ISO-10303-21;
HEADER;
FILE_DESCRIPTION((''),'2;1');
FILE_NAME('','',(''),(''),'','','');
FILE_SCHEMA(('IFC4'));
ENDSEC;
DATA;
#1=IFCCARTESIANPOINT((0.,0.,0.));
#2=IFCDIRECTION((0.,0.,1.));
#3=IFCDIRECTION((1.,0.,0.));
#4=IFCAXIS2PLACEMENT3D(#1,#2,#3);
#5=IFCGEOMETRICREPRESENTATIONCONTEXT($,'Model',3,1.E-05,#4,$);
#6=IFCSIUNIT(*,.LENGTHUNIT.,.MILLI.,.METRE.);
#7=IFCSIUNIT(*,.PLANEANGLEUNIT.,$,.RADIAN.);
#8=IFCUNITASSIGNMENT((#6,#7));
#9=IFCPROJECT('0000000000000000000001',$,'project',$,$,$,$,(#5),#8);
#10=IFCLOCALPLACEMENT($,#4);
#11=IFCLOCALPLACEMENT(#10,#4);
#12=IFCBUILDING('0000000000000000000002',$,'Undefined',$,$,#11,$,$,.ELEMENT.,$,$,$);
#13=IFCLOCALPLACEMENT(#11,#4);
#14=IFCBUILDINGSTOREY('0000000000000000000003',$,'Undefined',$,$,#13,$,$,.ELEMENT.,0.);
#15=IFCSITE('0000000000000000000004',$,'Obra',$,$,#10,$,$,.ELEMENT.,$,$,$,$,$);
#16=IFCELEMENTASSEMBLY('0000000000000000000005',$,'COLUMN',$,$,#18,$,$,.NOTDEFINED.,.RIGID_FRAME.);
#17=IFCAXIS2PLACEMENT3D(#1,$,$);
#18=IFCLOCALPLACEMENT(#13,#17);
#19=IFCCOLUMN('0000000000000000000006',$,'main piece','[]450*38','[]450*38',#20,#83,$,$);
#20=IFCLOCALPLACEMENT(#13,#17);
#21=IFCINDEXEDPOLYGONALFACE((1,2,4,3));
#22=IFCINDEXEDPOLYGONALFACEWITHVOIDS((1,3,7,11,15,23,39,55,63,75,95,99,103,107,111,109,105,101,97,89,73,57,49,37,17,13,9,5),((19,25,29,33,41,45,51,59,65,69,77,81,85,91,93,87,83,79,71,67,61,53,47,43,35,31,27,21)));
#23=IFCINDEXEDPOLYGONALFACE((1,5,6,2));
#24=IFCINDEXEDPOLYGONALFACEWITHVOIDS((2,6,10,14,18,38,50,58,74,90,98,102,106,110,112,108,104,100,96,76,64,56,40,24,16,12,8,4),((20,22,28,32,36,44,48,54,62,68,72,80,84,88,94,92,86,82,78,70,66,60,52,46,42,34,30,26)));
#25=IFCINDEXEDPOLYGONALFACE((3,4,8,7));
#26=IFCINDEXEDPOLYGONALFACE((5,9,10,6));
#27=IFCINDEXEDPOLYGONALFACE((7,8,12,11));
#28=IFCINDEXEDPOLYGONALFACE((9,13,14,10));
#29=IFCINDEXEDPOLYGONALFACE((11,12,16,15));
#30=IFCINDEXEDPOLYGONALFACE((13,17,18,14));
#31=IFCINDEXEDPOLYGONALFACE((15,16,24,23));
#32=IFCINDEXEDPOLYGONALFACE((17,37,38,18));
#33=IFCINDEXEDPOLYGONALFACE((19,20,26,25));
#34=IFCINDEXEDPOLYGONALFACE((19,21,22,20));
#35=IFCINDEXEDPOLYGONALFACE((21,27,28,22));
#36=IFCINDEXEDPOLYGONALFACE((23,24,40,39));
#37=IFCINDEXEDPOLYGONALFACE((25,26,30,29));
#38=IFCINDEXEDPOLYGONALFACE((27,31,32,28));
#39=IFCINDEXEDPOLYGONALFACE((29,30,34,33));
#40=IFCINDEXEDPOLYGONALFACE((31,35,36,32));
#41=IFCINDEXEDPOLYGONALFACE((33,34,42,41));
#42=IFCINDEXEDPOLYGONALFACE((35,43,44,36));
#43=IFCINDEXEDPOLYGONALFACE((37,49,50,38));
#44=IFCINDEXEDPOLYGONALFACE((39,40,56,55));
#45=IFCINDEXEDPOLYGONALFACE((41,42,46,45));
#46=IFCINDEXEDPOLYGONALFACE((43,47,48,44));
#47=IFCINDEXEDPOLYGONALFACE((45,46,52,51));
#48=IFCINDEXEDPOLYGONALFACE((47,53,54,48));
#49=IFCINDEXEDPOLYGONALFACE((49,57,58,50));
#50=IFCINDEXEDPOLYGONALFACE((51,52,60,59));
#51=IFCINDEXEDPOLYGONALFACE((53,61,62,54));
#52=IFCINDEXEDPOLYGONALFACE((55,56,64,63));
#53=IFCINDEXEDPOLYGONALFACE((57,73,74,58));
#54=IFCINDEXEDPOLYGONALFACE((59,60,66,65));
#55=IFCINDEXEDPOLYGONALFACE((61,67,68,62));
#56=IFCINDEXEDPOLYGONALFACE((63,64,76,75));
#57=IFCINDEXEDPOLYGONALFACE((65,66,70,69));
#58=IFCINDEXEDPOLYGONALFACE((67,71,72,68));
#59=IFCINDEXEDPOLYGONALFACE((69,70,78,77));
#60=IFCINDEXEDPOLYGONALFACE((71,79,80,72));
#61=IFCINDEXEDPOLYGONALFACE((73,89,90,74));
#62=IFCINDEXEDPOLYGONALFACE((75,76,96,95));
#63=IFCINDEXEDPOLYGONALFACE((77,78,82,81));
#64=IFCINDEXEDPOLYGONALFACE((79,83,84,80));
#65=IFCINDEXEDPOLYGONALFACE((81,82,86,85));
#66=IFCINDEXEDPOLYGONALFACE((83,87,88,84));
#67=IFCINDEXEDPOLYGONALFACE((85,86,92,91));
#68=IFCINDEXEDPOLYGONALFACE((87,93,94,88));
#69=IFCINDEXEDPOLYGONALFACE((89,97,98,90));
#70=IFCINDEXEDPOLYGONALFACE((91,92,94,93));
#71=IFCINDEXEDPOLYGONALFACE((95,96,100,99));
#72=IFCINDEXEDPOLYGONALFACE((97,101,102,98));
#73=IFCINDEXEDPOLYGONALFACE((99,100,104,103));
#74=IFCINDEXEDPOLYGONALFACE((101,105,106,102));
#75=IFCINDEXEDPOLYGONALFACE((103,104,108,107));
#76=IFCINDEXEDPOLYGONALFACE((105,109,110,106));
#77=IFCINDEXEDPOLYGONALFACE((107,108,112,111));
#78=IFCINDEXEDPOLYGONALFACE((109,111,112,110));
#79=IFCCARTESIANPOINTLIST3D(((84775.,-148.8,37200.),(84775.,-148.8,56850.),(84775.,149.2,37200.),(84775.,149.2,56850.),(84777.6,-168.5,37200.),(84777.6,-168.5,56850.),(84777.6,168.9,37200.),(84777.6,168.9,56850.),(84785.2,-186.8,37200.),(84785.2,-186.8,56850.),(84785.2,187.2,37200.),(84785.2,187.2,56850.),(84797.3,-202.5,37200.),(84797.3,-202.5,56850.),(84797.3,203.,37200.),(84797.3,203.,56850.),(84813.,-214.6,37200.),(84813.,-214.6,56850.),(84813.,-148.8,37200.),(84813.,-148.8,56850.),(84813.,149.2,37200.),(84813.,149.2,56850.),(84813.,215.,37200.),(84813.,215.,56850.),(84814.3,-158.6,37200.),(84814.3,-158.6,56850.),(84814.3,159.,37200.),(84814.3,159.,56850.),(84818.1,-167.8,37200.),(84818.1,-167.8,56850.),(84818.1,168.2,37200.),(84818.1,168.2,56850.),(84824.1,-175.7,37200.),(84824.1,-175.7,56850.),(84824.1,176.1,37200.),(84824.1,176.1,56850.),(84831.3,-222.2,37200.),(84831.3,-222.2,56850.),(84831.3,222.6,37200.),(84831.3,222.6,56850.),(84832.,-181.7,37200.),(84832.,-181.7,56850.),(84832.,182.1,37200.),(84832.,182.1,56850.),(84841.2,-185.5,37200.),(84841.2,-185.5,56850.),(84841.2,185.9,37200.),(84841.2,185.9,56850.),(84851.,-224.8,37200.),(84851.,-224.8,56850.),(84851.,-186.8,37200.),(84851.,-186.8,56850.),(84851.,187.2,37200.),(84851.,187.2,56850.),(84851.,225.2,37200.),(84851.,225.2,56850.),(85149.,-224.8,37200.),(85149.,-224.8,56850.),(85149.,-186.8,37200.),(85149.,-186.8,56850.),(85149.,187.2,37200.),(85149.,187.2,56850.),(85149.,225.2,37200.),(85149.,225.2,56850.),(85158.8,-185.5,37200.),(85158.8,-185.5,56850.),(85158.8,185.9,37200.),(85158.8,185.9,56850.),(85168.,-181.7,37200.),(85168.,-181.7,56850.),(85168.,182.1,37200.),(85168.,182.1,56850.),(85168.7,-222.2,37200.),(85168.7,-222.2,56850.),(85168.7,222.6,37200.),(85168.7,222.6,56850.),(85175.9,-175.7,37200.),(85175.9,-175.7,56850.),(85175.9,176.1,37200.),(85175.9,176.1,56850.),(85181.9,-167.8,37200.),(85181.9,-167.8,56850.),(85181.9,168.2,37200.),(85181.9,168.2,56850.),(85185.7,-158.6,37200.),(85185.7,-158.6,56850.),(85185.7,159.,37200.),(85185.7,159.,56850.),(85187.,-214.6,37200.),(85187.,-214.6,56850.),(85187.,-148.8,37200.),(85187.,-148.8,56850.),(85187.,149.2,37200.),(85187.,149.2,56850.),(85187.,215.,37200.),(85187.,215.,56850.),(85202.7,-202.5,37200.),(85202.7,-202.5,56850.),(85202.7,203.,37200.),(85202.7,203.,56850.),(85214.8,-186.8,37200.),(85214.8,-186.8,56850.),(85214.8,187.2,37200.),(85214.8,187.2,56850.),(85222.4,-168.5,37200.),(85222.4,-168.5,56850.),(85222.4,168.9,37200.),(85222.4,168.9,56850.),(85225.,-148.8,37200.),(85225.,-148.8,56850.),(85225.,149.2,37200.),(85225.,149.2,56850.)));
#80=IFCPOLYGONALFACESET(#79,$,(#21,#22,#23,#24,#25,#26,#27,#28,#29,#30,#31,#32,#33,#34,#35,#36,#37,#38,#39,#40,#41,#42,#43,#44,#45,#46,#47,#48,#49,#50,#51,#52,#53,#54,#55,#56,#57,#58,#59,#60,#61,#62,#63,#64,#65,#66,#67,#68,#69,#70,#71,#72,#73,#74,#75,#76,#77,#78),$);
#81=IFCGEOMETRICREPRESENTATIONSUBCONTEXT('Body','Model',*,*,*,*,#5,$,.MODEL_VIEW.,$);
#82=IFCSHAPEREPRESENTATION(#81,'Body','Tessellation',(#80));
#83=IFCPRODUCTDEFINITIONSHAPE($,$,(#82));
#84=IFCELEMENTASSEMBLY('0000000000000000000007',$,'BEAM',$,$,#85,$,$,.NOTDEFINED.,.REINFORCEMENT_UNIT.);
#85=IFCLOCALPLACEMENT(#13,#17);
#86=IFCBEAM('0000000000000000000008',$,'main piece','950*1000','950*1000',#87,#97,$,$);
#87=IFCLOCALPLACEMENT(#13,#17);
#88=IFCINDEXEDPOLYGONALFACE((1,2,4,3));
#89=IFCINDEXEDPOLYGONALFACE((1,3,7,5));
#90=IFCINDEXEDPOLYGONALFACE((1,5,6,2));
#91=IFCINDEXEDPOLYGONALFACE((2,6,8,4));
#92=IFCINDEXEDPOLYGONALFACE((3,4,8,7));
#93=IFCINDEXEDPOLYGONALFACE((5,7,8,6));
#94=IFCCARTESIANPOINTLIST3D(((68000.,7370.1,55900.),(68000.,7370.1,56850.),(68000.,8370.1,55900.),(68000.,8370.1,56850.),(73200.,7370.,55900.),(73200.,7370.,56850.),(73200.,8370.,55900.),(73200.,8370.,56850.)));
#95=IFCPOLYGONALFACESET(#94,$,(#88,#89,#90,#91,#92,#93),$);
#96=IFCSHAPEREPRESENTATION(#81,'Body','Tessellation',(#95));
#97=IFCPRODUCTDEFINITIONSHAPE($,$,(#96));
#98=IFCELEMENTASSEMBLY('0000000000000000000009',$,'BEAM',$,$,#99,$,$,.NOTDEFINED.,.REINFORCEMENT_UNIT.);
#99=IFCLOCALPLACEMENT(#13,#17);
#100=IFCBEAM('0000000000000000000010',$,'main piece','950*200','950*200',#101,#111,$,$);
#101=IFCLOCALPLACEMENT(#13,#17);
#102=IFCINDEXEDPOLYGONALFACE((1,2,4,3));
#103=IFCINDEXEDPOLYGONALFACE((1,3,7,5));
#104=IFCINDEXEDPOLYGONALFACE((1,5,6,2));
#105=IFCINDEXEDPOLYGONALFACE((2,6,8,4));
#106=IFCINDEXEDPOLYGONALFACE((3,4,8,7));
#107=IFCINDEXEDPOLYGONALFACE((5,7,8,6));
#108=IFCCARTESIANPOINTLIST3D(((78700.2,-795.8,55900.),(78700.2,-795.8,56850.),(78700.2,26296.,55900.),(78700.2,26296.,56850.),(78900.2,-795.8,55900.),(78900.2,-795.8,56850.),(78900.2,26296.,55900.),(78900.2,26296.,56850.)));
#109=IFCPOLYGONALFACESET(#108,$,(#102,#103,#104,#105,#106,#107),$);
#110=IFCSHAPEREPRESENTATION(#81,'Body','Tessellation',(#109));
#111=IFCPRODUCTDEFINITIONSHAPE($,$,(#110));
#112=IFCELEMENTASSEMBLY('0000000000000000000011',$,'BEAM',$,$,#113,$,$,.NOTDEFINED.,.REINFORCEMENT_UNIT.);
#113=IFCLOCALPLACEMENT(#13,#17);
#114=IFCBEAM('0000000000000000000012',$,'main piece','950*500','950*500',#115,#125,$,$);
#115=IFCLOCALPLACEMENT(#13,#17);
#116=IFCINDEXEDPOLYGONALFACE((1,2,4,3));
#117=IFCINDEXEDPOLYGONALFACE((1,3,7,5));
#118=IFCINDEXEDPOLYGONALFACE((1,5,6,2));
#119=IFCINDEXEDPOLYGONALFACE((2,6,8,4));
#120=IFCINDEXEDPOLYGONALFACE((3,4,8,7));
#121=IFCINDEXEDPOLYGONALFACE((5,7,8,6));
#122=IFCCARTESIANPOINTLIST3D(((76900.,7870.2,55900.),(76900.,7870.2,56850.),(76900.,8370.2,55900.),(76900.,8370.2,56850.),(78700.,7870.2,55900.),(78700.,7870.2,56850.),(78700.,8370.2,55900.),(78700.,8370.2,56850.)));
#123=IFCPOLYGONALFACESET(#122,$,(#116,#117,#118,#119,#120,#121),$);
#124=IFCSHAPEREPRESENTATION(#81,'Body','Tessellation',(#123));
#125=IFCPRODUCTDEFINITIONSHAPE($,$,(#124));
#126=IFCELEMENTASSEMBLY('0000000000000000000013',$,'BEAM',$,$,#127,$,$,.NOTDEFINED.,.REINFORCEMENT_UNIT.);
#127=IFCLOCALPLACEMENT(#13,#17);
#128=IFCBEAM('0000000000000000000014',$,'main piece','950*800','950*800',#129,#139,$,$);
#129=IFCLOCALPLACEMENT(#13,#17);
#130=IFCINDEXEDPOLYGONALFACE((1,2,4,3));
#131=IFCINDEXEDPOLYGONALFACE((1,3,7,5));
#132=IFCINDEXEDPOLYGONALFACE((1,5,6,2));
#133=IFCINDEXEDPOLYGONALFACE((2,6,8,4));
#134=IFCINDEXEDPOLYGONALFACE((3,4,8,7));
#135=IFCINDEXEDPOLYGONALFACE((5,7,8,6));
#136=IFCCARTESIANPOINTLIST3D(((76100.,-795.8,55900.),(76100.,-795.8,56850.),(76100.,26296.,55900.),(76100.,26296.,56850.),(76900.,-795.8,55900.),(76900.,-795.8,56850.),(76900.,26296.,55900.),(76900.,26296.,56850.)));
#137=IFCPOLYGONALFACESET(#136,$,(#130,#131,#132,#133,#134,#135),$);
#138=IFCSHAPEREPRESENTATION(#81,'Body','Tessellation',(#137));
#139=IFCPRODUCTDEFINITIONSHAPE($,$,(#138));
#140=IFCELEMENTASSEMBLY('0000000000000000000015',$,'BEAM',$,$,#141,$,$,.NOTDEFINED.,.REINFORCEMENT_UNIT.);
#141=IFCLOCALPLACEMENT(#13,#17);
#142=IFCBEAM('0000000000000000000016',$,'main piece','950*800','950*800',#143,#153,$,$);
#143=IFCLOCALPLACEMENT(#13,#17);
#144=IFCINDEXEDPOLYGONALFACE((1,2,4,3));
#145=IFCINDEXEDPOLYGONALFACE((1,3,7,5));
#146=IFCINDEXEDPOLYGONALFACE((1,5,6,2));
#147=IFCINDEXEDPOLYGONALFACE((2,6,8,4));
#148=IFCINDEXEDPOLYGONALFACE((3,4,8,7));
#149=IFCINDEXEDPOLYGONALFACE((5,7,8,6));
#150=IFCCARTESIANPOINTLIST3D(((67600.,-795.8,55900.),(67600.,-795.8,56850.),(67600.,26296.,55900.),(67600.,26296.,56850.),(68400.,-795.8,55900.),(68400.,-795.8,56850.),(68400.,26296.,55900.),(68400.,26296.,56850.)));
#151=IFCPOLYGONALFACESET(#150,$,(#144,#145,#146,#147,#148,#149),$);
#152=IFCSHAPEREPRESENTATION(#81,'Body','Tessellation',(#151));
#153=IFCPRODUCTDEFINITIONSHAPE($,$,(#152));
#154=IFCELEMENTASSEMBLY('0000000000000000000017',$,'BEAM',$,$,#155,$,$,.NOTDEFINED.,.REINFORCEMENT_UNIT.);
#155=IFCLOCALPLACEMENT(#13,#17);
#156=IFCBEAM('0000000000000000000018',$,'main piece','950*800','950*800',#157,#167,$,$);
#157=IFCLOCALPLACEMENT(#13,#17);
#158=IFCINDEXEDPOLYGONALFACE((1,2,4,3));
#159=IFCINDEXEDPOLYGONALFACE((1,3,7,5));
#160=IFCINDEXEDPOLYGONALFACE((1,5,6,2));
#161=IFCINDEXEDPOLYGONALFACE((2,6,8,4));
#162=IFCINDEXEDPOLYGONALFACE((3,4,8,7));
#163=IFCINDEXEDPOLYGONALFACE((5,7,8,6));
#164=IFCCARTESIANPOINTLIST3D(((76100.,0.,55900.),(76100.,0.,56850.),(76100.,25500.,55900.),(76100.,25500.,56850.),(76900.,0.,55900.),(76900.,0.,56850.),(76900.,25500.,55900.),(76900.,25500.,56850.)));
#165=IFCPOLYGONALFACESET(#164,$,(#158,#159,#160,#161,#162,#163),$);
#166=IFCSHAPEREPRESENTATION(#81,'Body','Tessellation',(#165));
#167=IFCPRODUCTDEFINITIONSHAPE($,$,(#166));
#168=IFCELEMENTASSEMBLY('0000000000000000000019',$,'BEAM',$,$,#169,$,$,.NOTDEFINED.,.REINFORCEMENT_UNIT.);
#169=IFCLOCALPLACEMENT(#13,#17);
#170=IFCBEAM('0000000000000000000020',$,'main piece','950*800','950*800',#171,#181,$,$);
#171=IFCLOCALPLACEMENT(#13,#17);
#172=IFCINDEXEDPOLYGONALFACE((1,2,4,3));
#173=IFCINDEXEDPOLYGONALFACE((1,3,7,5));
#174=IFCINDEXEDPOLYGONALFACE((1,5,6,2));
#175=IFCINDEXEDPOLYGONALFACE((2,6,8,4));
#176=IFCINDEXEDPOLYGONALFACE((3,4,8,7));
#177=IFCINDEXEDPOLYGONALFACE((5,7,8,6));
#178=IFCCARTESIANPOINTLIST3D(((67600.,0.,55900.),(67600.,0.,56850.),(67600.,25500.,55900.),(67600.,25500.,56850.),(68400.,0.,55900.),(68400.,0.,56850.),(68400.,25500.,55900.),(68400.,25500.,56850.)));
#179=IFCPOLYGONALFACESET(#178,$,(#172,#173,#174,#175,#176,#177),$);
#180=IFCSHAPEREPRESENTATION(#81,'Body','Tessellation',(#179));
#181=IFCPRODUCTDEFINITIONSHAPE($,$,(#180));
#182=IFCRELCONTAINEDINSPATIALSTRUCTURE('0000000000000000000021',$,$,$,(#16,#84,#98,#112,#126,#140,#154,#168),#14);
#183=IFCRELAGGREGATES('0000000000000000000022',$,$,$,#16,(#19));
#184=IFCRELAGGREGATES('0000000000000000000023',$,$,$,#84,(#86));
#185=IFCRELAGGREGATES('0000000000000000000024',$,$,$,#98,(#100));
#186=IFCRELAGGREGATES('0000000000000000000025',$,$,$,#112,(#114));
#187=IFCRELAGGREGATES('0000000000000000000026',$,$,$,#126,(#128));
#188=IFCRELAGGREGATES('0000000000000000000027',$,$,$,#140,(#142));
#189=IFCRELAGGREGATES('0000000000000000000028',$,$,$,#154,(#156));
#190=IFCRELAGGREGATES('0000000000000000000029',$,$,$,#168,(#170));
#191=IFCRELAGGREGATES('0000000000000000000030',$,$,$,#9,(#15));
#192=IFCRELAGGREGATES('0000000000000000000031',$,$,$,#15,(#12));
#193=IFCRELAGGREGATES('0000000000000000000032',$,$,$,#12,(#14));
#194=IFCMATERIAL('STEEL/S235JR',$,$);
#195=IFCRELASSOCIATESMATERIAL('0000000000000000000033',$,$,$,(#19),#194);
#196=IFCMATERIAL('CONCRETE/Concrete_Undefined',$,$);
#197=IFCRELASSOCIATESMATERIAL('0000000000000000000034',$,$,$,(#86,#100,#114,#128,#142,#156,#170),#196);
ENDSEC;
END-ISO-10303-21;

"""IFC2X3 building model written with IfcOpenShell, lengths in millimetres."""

from ifc_helpers import new_model, si_unit, frame, origin_with_axes, origin_2d_with_axis, place, context, subcontext, project, spatial, rectangle, hollow_rectangle, extrude, material, element, aggregate, save


model = new_model("IFC2X3")

# Units and contexts
model_context = context("Model", 3, precision=1e-05, world=origin_with_axes())
body_context = subcontext(model_context, "Body", "Model", "MODEL_VIEW")
ifc_project = project(units=[si_unit("LENGTHUNIT", "METRE", prefix="MILLI"), si_unit("PLANEANGLEUNIT", "RADIAN")], contexts=[model_context])

# Site, building, storey
site_placement = place(None, origin_with_axes())
site = spatial("IfcSite", under=ifc_project, at=site_placement, Name="Obra", CompositionType="ELEMENT")
building_placement = place(site_placement, origin_with_axes())
building = spatial("IfcBuilding", under=site, at=building_placement, Name="Undefined", CompositionType="ELEMENT")
storey_placement = place(building_placement, origin_with_axes())
storey = spatial("IfcBuildingStorey", under=building, at=storey_placement, Name="Undefined", CompositionType="ELEMENT", Elevation=0.0)

# Element assembly, column
ifc_material_1 = material(Name="STEEL/S235JR")
assembly_1_placement = place(storey_placement, origin_with_axes())
assembly_1 = element("IfcElementAssembly", 1, at=assembly_1_placement, inside=storey, Name="COLUMN", AssemblyPlace="NOTDEFINED", PredefinedType="RIGID_FRAME")
column_1_placement = place(assembly_1_placement, frame((85000.0, 0.2, 37200.0), z_axis=(0.0, 0.0, 1.0), x_axis=(0.0, 1.0, 0.0)))
column_1 = element("IfcColumn", 2, at=column_1_placement, material=ifc_material_1, Name="main piece", Description="[]450*38", ObjectType="[]450*38", context=body_context, shape_type="SweptSolid", body=[
    extrude(hollow_rectangle(XDim=450.0, YDim=450.0, WallThickness=38.0, InnerFilletRadius=38.0, OuterFilletRadius=76.0, at=origin_2d_with_axis()), frame((0.0, 0.0, 19650.0), z_axis=(0.0, 0.0, -1.0), x_axis=(0.0, 1.0, 0.0)), (0.0, 0.0, 1.0), 19650.0),
])
aggregate(assembly_1, [column_1])

# Element assemblies, beams
assembly_2_placement = place(storey_placement, origin_with_axes())
assembly_2 = element("IfcElementAssembly", 3, at=assembly_2_placement, inside=storey, Name="BEAM", AssemblyPlace="NOTDEFINED", PredefinedType="REINFORCEMENT_UNIT")
ifc_material_2 = material(Name="CONCRETE/Concrete_Undefined")
beam_1_placement = place(assembly_2_placement, frame((68000.0, 7870.1, 56375.0), z_axis=(0.0, 0.0, 1.0), x_axis=(1.0, -0.000019, 0.0)))
beam_1 = element("IfcBeam", 4, at=beam_1_placement, material=ifc_material_2, Name="main piece", Description="950*1000", ObjectType="950*1000", context=body_context, shape_type="SweptSolid", body=[
    extrude(rectangle(XDim=1000.0, YDim=950.0, at=origin_2d_with_axis()), frame((5200.0, 0.0, 0.0), z_axis=(-1.0, 0.0, 0.0), x_axis=(0.0, -1.0, 0.0)), (0.0, 0.0, 1.0), 5200.0),
])
aggregate(assembly_2, [beam_1])
assembly_3_placement = place(storey_placement, origin_with_axes())
assembly_3 = element("IfcElementAssembly", 5, at=assembly_3_placement, inside=storey, Name="BEAM", AssemblyPlace="NOTDEFINED", PredefinedType="REINFORCEMENT_UNIT")
beam_2_placement = place(assembly_3_placement, frame((78800.2, -795.8, 56375.0), z_axis=(0.0, 0.0, 1.0), x_axis=(0.0, 1.0, 0.0)))
beam_2 = element("IfcBeam", 6, at=beam_2_placement, material=ifc_material_2, Name="main piece", Description="950*200", ObjectType="950*200", context=body_context, shape_type="SweptSolid", body=[
    extrude(rectangle(XDim=200.0, YDim=950.0, at=origin_2d_with_axis()), frame((27091.8, 0.0, 0.0), z_axis=(-1.0, 0.0, 0.0), x_axis=(0.0, -1.0, 0.0)), (0.0, 0.0, 1.0), 27091.8),
])
aggregate(assembly_3, [beam_2])
assembly_4_placement = place(storey_placement, origin_with_axes())
assembly_4 = element("IfcElementAssembly", 7, at=assembly_4_placement, inside=storey, Name="BEAM", AssemblyPlace="NOTDEFINED", PredefinedType="REINFORCEMENT_UNIT")
beam_3_placement = place(assembly_4_placement, frame((78700.0, 8120.2, 56375.0), z_axis=(0.0, 0.0, 1.0), x_axis=(-1.0, 0.0, 0.0)))
beam_3 = element("IfcBeam", 8, at=beam_3_placement, material=ifc_material_2, Name="main piece", Description="950*500", ObjectType="950*500", context=body_context, shape_type="SweptSolid", body=[
    extrude(rectangle(XDim=500.0, YDim=950.0, at=origin_2d_with_axis()), frame((1800.0, 0.0, 0.0), z_axis=(-1.0, 0.0, 0.0), x_axis=(0.0, -1.0, 0.0)), (0.0, 0.0, 1.0), 1800.0),
])
aggregate(assembly_4, [beam_3])
assembly_5_placement = place(storey_placement, origin_with_axes())
assembly_5 = element("IfcElementAssembly", 9, at=assembly_5_placement, inside=storey, Name="BEAM", AssemblyPlace="NOTDEFINED", PredefinedType="REINFORCEMENT_UNIT")
beam_4_placement = place(assembly_5_placement, frame((76500.0, -795.8, 56375.0), z_axis=(0.0, 0.0, 1.0), x_axis=(0.0, 1.0, 0.0)))
beam_4 = element("IfcBeam", 10, at=beam_4_placement, material=ifc_material_2, Name="main piece", Description="950*800", ObjectType="950*800", context=body_context, shape_type="SweptSolid", body=[
    extrude(rectangle(XDim=800.0, YDim=950.0, at=origin_2d_with_axis()), frame((27091.8, 0.0, 0.0), z_axis=(-1.0, 0.0, 0.0), x_axis=(0.0, -1.0, 0.0)), (0.0, 0.0, 1.0), 27091.8),
])
aggregate(assembly_5, [beam_4])
assembly_6_placement = place(storey_placement, origin_with_axes())
assembly_6 = element("IfcElementAssembly", 11, at=assembly_6_placement, inside=storey, Name="BEAM", AssemblyPlace="NOTDEFINED", PredefinedType="REINFORCEMENT_UNIT")
beam_5_placement = place(assembly_6_placement, frame((68000.0, -795.8, 56375.0), z_axis=(0.0, 0.0, 1.0), x_axis=(0.0, 1.0, 0.0)))
beam_5 = element("IfcBeam", 12, at=beam_5_placement, material=ifc_material_2, Name="main piece", Description="950*800", ObjectType="950*800", context=body_context, shape_type="SweptSolid", body=[
    extrude(rectangle(XDim=800.0, YDim=950.0, at=origin_2d_with_axis()), frame((27091.8, 0.0, 0.0), z_axis=(-1.0, 0.0, 0.0), x_axis=(0.0, -1.0, 0.0)), (0.0, 0.0, 1.0), 27091.8),
])
aggregate(assembly_6, [beam_5])
assembly_7_placement = place(storey_placement, origin_with_axes())
assembly_7 = element("IfcElementAssembly", 13, at=assembly_7_placement, inside=storey, Name="BEAM", AssemblyPlace="NOTDEFINED", PredefinedType="REINFORCEMENT_UNIT")
beam_6_placement = place(assembly_7_placement, frame((76500.0, 0.0, 56375.0), z_axis=(0.0, 0.0, 1.0), x_axis=(0.0, 1.0, 0.0)))
beam_6 = element("IfcBeam", 14, at=beam_6_placement, material=ifc_material_2, Name="main piece", Description="950*800", ObjectType="950*800", context=body_context, shape_type="SweptSolid", body=[
    extrude(rectangle(XDim=800.0, YDim=950.0, at=origin_2d_with_axis()), frame((25500.0, 0.0, 0.0), z_axis=(-1.0, 0.0, 0.0), x_axis=(0.0, -1.0, 0.0)), (0.0, 0.0, 1.0), 25500.0),
])
aggregate(assembly_7, [beam_6])
assembly_8_placement = place(storey_placement, origin_with_axes())
assembly_8 = element("IfcElementAssembly", 15, at=assembly_8_placement, inside=storey, Name="BEAM", AssemblyPlace="NOTDEFINED", PredefinedType="REINFORCEMENT_UNIT")
beam_7_placement = place(assembly_8_placement, frame((68000.0, 0.0, 56375.0), z_axis=(0.0, 0.0, 1.0), x_axis=(0.0, 1.0, 0.0)))
beam_7 = element("IfcBeam", 16, at=beam_7_placement, material=ifc_material_2, Name="main piece", Description="950*800", ObjectType="950*800", context=body_context, shape_type="SweptSolid", body=[
    extrude(rectangle(XDim=800.0, YDim=950.0, at=origin_2d_with_axis()), frame((25500.0, 0.0, 0.0), z_axis=(-1.0, 0.0, 0.0), x_axis=(0.0, -1.0, 0.0)), (0.0, 0.0, 1.0), 25500.0),
])
aggregate(assembly_8, [beam_7])

save(model, "model.ifc")
